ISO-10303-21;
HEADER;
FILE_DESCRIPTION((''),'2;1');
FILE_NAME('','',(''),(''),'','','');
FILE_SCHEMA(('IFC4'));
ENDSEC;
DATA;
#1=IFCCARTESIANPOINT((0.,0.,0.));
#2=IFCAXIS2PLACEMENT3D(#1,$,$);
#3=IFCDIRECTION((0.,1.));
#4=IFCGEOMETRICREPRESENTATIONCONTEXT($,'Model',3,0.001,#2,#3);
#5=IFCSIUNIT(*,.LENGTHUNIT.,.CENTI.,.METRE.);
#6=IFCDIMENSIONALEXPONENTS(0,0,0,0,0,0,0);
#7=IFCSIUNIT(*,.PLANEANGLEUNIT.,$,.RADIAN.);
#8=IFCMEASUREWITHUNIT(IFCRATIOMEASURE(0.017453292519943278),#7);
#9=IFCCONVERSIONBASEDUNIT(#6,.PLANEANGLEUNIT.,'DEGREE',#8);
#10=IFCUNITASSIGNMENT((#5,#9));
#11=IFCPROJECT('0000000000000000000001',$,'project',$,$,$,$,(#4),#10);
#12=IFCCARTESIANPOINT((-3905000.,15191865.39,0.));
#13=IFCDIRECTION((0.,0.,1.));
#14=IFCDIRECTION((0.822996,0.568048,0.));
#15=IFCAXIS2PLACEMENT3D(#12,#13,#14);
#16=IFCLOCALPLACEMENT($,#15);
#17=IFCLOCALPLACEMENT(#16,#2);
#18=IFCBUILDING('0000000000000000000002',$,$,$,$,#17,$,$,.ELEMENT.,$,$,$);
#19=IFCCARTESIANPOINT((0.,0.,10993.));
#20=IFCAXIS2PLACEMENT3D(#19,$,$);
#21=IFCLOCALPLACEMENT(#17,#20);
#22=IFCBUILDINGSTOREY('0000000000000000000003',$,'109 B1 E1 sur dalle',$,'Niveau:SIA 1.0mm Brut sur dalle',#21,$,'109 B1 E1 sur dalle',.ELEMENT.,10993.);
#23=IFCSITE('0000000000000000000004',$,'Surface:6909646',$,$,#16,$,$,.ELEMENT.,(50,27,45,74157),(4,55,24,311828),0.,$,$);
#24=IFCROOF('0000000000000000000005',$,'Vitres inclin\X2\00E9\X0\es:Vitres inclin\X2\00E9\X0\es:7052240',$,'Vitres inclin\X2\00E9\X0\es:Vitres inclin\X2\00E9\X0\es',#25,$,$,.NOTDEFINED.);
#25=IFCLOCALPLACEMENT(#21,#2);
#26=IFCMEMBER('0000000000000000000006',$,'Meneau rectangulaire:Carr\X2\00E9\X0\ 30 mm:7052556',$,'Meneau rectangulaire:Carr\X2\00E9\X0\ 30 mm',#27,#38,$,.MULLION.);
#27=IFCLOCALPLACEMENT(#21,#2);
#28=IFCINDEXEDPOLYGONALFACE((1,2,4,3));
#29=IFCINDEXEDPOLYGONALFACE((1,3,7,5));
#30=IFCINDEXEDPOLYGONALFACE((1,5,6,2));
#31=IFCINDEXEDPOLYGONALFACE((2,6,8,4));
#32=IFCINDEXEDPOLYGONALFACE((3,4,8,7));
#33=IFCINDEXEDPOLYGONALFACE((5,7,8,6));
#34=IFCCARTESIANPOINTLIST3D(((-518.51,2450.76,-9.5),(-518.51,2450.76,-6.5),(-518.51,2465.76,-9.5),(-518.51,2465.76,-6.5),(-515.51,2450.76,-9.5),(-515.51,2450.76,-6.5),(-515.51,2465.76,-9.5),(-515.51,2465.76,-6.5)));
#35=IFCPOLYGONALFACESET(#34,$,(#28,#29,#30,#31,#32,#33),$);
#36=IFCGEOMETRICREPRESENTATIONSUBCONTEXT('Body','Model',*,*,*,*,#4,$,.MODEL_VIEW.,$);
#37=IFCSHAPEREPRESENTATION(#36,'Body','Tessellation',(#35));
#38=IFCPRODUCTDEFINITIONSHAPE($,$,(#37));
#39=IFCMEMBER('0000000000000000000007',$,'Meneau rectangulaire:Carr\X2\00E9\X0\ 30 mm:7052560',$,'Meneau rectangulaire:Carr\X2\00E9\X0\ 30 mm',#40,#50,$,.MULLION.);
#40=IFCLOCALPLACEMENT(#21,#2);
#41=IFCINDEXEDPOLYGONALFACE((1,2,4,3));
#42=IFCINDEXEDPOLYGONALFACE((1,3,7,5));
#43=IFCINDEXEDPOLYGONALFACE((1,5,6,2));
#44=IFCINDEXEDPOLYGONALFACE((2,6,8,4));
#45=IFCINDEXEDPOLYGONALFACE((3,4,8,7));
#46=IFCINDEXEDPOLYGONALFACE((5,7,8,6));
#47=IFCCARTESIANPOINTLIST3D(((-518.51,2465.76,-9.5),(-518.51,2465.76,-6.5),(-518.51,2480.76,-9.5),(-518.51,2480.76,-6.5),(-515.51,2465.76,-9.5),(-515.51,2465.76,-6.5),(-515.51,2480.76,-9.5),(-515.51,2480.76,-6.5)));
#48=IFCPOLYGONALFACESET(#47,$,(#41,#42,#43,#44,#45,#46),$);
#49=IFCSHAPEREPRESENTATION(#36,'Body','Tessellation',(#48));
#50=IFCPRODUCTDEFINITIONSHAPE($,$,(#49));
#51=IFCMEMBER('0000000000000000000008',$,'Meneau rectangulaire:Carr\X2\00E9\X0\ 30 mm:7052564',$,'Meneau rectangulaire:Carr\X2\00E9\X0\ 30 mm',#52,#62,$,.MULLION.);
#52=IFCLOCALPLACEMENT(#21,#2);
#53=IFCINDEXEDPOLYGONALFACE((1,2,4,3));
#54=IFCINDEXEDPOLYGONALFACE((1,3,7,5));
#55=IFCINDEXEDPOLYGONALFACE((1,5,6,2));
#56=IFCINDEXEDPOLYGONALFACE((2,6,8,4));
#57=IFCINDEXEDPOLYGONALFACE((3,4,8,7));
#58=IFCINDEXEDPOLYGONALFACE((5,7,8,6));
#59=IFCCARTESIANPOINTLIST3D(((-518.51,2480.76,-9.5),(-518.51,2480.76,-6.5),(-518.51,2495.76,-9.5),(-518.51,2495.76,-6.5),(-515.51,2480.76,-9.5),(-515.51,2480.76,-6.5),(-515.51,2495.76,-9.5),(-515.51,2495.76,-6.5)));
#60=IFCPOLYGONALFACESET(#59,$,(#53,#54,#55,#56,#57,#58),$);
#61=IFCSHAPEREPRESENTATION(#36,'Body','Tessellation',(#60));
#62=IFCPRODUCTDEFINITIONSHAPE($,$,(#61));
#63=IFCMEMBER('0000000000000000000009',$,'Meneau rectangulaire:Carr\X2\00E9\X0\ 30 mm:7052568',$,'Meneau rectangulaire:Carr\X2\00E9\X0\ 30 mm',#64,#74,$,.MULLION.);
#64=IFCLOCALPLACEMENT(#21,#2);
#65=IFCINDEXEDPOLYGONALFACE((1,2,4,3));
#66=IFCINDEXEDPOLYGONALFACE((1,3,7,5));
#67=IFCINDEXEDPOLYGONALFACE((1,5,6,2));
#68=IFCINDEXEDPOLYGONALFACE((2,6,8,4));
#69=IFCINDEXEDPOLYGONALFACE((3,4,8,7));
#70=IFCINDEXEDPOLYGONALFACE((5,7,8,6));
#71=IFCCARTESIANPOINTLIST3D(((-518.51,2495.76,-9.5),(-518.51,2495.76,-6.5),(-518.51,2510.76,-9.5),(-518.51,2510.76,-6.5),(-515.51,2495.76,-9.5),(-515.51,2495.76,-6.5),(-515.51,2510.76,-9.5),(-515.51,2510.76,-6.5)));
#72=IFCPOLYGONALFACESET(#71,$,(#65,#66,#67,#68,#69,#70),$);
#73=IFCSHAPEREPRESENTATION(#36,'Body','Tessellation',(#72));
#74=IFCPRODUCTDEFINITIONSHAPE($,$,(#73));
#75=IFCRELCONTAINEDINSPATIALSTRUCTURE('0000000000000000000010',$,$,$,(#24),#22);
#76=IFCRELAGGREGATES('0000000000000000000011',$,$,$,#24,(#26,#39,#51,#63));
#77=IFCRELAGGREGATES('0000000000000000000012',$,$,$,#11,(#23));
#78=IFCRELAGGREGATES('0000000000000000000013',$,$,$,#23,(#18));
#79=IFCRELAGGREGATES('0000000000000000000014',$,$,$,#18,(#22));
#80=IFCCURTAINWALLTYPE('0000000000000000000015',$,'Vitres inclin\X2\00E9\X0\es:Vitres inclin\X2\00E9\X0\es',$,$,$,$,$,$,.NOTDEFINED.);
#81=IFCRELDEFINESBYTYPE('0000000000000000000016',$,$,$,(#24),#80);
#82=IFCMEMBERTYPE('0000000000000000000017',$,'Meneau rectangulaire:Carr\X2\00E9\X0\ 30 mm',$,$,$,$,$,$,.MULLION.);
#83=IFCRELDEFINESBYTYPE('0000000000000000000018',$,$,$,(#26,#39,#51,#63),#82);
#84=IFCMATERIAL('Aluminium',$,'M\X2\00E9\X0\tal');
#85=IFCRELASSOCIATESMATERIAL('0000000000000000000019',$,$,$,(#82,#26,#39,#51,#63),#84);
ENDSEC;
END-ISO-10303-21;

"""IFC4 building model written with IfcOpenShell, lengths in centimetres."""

from ifc_helpers import new_model, entity, si_unit, converted_unit, direction, frame, origin, place, context, subcontext, project, spatial, indexed_curve, outline, extrude, source, transform, mapped, material, type_object, type_shapes, element, aggregate, save


model = new_model("IFC4")

# Units and contexts
model_context = context("Model", 3, precision=0.001, world=origin(), true_north=direction((0.0, 1.0)))
body_context = subcontext(model_context, "Body", "Model", "MODEL_VIEW")
ifc_project = project(units=[si_unit("LENGTHUNIT", "METRE", prefix="CENTI"), converted_unit("PLANEANGLEUNIT", "DEGREE", entity("IfcRatioMeasure", 0.017453292519943278), si_unit("PLANEANGLEUNIT", "RADIAN"), dimensions=[0, 0, 0, 0, 0, 0, 0])], contexts=[model_context])

# Site, building, storey
site_placement = place(None, frame((-3905000.0, 15191865.39, 0.0), z_axis=(0.0, 0.0, 1.0), x_axis=(0.822996, 0.568048, 0.0)))
site = spatial("IfcSite", under=ifc_project, at=site_placement, Name="Surface:6909646", CompositionType="ELEMENT", RefLatitude=(50, 27, 45, 74157), RefLongitude=(4, 55, 24, 311828), RefElevation=0.0)
building_placement = place(site_placement, origin())
building = spatial("IfcBuilding", under=site, at=building_placement, CompositionType="ELEMENT")
storey_placement = place(building_placement, frame((0.0, 0.0, 10993.0)))
storey = spatial("IfcBuildingStorey", under=building, at=storey_placement, Name="109 B1 E1 sur dalle", ObjectType="Niveau:SIA 1.0mm Brut sur dalle", LongName="109 B1 E1 sur dalle", CompositionType="ELEMENT", Elevation=10993.0)

# Roof, members
curtain_wall_type = type_object("IfcCurtainWallType", Name="Vitres inclinées:Vitres inclinées", PredefinedType="NOTDEFINED")
roof_placement = place(storey_placement, frame((0.0, 0.0, -10993.0)))
roof = element("IfcRoof", 1, at=roof_placement, inside=storey, type_object=curtain_wall_type, Name="Vitres inclinées:Vitres inclinées:7052240", ObjectType="Vitres inclinées:Vitres inclinées", PredefinedType="NOTDEFINED")
ifc_material = material(Name="Aluminium", Category="Métal")
member_type_1 = type_object("IfcMemberType", Name="Meneau rectangulaire:Carré 30 mm", PredefinedType="MULLION", material=ifc_material)
shared_shape_1 = source(origin(), body_context, "Body", "SweptSolid", [
    extrude(outline(indexed_curve([(-1.5, -1.5), (1.5, -1.5), (1.5, 1.5), (-1.5, 1.5), (-1.5, -1.5)], self_intersect=False)), frame((0.0, 0.0, -15.0), z_axis=(0.0, 0.0, 1.0), x_axis=(0.0, -1.0, 0.0)), (0.0, 0.0, 1.0), 15.0),
])
type_shapes(member_type_1, [shared_shape_1])
member_1_placement = place(roof_placement, frame((-517.01, 2465.76, 10985.0), z_axis=(0.0, 1.0, 0.0), x_axis=(1.0, 0.0, 0.0)))
member_1 = element("IfcMember", 2, at=member_1_placement, type_object=member_type_1, material=ifc_material, Name="Meneau rectangulaire:Carré 30 mm:7052556", ObjectType="Meneau rectangulaire:Carré 30 mm", PredefinedType="MULLION", context=body_context, shape_type="MappedRepresentation", body=[
    mapped(shared_shape_1, transform((0.0, 0.0, 0.0), scale=1.0)),
])
member_2_placement = place(roof_placement, frame((-517.01, 2480.76, 10985.0), z_axis=(0.0, 1.0, 0.0), x_axis=(1.0, 0.0, 0.0)))
member_2 = element("IfcMember", 3, at=member_2_placement, type_object=member_type_1, material=ifc_material, Name="Meneau rectangulaire:Carré 30 mm:7052560", ObjectType="Meneau rectangulaire:Carré 30 mm", PredefinedType="MULLION", context=body_context, shape_type="MappedRepresentation", body=[
    mapped(shared_shape_1, transform((0.0, 0.0, 0.0), scale=1.0)),
])
member_3_placement = place(roof_placement, frame((-517.01, 2495.76, 10985.0), z_axis=(0.0, 1.0, 0.0), x_axis=(1.0, 0.0, 0.0)))
member_3 = element("IfcMember", 4, at=member_3_placement, type_object=member_type_1, material=ifc_material, Name="Meneau rectangulaire:Carré 30 mm:7052564", ObjectType="Meneau rectangulaire:Carré 30 mm", PredefinedType="MULLION", context=body_context, shape_type="MappedRepresentation", body=[
    mapped(shared_shape_1, transform((0.0, 0.0, 0.0), scale=1.0)),
])
member_4_placement = place(roof_placement, frame((-517.01, 2510.76, 10985.0), z_axis=(0.0, 1.0, 0.0), x_axis=(1.0, 0.0, 0.0)))
member_4 = element("IfcMember", 5, at=member_4_placement, type_object=member_type_1, material=ifc_material, Name="Meneau rectangulaire:Carré 30 mm:7052568", ObjectType="Meneau rectangulaire:Carré 30 mm", PredefinedType="MULLION", context=body_context, shape_type="MappedRepresentation", body=[
    mapped(shared_shape_1, transform((0.0, 0.0, 0.0), scale=1.0)),
])
aggregate(roof, [member_1, member_2, member_3, member_4])

save(model, "model.ifc")
